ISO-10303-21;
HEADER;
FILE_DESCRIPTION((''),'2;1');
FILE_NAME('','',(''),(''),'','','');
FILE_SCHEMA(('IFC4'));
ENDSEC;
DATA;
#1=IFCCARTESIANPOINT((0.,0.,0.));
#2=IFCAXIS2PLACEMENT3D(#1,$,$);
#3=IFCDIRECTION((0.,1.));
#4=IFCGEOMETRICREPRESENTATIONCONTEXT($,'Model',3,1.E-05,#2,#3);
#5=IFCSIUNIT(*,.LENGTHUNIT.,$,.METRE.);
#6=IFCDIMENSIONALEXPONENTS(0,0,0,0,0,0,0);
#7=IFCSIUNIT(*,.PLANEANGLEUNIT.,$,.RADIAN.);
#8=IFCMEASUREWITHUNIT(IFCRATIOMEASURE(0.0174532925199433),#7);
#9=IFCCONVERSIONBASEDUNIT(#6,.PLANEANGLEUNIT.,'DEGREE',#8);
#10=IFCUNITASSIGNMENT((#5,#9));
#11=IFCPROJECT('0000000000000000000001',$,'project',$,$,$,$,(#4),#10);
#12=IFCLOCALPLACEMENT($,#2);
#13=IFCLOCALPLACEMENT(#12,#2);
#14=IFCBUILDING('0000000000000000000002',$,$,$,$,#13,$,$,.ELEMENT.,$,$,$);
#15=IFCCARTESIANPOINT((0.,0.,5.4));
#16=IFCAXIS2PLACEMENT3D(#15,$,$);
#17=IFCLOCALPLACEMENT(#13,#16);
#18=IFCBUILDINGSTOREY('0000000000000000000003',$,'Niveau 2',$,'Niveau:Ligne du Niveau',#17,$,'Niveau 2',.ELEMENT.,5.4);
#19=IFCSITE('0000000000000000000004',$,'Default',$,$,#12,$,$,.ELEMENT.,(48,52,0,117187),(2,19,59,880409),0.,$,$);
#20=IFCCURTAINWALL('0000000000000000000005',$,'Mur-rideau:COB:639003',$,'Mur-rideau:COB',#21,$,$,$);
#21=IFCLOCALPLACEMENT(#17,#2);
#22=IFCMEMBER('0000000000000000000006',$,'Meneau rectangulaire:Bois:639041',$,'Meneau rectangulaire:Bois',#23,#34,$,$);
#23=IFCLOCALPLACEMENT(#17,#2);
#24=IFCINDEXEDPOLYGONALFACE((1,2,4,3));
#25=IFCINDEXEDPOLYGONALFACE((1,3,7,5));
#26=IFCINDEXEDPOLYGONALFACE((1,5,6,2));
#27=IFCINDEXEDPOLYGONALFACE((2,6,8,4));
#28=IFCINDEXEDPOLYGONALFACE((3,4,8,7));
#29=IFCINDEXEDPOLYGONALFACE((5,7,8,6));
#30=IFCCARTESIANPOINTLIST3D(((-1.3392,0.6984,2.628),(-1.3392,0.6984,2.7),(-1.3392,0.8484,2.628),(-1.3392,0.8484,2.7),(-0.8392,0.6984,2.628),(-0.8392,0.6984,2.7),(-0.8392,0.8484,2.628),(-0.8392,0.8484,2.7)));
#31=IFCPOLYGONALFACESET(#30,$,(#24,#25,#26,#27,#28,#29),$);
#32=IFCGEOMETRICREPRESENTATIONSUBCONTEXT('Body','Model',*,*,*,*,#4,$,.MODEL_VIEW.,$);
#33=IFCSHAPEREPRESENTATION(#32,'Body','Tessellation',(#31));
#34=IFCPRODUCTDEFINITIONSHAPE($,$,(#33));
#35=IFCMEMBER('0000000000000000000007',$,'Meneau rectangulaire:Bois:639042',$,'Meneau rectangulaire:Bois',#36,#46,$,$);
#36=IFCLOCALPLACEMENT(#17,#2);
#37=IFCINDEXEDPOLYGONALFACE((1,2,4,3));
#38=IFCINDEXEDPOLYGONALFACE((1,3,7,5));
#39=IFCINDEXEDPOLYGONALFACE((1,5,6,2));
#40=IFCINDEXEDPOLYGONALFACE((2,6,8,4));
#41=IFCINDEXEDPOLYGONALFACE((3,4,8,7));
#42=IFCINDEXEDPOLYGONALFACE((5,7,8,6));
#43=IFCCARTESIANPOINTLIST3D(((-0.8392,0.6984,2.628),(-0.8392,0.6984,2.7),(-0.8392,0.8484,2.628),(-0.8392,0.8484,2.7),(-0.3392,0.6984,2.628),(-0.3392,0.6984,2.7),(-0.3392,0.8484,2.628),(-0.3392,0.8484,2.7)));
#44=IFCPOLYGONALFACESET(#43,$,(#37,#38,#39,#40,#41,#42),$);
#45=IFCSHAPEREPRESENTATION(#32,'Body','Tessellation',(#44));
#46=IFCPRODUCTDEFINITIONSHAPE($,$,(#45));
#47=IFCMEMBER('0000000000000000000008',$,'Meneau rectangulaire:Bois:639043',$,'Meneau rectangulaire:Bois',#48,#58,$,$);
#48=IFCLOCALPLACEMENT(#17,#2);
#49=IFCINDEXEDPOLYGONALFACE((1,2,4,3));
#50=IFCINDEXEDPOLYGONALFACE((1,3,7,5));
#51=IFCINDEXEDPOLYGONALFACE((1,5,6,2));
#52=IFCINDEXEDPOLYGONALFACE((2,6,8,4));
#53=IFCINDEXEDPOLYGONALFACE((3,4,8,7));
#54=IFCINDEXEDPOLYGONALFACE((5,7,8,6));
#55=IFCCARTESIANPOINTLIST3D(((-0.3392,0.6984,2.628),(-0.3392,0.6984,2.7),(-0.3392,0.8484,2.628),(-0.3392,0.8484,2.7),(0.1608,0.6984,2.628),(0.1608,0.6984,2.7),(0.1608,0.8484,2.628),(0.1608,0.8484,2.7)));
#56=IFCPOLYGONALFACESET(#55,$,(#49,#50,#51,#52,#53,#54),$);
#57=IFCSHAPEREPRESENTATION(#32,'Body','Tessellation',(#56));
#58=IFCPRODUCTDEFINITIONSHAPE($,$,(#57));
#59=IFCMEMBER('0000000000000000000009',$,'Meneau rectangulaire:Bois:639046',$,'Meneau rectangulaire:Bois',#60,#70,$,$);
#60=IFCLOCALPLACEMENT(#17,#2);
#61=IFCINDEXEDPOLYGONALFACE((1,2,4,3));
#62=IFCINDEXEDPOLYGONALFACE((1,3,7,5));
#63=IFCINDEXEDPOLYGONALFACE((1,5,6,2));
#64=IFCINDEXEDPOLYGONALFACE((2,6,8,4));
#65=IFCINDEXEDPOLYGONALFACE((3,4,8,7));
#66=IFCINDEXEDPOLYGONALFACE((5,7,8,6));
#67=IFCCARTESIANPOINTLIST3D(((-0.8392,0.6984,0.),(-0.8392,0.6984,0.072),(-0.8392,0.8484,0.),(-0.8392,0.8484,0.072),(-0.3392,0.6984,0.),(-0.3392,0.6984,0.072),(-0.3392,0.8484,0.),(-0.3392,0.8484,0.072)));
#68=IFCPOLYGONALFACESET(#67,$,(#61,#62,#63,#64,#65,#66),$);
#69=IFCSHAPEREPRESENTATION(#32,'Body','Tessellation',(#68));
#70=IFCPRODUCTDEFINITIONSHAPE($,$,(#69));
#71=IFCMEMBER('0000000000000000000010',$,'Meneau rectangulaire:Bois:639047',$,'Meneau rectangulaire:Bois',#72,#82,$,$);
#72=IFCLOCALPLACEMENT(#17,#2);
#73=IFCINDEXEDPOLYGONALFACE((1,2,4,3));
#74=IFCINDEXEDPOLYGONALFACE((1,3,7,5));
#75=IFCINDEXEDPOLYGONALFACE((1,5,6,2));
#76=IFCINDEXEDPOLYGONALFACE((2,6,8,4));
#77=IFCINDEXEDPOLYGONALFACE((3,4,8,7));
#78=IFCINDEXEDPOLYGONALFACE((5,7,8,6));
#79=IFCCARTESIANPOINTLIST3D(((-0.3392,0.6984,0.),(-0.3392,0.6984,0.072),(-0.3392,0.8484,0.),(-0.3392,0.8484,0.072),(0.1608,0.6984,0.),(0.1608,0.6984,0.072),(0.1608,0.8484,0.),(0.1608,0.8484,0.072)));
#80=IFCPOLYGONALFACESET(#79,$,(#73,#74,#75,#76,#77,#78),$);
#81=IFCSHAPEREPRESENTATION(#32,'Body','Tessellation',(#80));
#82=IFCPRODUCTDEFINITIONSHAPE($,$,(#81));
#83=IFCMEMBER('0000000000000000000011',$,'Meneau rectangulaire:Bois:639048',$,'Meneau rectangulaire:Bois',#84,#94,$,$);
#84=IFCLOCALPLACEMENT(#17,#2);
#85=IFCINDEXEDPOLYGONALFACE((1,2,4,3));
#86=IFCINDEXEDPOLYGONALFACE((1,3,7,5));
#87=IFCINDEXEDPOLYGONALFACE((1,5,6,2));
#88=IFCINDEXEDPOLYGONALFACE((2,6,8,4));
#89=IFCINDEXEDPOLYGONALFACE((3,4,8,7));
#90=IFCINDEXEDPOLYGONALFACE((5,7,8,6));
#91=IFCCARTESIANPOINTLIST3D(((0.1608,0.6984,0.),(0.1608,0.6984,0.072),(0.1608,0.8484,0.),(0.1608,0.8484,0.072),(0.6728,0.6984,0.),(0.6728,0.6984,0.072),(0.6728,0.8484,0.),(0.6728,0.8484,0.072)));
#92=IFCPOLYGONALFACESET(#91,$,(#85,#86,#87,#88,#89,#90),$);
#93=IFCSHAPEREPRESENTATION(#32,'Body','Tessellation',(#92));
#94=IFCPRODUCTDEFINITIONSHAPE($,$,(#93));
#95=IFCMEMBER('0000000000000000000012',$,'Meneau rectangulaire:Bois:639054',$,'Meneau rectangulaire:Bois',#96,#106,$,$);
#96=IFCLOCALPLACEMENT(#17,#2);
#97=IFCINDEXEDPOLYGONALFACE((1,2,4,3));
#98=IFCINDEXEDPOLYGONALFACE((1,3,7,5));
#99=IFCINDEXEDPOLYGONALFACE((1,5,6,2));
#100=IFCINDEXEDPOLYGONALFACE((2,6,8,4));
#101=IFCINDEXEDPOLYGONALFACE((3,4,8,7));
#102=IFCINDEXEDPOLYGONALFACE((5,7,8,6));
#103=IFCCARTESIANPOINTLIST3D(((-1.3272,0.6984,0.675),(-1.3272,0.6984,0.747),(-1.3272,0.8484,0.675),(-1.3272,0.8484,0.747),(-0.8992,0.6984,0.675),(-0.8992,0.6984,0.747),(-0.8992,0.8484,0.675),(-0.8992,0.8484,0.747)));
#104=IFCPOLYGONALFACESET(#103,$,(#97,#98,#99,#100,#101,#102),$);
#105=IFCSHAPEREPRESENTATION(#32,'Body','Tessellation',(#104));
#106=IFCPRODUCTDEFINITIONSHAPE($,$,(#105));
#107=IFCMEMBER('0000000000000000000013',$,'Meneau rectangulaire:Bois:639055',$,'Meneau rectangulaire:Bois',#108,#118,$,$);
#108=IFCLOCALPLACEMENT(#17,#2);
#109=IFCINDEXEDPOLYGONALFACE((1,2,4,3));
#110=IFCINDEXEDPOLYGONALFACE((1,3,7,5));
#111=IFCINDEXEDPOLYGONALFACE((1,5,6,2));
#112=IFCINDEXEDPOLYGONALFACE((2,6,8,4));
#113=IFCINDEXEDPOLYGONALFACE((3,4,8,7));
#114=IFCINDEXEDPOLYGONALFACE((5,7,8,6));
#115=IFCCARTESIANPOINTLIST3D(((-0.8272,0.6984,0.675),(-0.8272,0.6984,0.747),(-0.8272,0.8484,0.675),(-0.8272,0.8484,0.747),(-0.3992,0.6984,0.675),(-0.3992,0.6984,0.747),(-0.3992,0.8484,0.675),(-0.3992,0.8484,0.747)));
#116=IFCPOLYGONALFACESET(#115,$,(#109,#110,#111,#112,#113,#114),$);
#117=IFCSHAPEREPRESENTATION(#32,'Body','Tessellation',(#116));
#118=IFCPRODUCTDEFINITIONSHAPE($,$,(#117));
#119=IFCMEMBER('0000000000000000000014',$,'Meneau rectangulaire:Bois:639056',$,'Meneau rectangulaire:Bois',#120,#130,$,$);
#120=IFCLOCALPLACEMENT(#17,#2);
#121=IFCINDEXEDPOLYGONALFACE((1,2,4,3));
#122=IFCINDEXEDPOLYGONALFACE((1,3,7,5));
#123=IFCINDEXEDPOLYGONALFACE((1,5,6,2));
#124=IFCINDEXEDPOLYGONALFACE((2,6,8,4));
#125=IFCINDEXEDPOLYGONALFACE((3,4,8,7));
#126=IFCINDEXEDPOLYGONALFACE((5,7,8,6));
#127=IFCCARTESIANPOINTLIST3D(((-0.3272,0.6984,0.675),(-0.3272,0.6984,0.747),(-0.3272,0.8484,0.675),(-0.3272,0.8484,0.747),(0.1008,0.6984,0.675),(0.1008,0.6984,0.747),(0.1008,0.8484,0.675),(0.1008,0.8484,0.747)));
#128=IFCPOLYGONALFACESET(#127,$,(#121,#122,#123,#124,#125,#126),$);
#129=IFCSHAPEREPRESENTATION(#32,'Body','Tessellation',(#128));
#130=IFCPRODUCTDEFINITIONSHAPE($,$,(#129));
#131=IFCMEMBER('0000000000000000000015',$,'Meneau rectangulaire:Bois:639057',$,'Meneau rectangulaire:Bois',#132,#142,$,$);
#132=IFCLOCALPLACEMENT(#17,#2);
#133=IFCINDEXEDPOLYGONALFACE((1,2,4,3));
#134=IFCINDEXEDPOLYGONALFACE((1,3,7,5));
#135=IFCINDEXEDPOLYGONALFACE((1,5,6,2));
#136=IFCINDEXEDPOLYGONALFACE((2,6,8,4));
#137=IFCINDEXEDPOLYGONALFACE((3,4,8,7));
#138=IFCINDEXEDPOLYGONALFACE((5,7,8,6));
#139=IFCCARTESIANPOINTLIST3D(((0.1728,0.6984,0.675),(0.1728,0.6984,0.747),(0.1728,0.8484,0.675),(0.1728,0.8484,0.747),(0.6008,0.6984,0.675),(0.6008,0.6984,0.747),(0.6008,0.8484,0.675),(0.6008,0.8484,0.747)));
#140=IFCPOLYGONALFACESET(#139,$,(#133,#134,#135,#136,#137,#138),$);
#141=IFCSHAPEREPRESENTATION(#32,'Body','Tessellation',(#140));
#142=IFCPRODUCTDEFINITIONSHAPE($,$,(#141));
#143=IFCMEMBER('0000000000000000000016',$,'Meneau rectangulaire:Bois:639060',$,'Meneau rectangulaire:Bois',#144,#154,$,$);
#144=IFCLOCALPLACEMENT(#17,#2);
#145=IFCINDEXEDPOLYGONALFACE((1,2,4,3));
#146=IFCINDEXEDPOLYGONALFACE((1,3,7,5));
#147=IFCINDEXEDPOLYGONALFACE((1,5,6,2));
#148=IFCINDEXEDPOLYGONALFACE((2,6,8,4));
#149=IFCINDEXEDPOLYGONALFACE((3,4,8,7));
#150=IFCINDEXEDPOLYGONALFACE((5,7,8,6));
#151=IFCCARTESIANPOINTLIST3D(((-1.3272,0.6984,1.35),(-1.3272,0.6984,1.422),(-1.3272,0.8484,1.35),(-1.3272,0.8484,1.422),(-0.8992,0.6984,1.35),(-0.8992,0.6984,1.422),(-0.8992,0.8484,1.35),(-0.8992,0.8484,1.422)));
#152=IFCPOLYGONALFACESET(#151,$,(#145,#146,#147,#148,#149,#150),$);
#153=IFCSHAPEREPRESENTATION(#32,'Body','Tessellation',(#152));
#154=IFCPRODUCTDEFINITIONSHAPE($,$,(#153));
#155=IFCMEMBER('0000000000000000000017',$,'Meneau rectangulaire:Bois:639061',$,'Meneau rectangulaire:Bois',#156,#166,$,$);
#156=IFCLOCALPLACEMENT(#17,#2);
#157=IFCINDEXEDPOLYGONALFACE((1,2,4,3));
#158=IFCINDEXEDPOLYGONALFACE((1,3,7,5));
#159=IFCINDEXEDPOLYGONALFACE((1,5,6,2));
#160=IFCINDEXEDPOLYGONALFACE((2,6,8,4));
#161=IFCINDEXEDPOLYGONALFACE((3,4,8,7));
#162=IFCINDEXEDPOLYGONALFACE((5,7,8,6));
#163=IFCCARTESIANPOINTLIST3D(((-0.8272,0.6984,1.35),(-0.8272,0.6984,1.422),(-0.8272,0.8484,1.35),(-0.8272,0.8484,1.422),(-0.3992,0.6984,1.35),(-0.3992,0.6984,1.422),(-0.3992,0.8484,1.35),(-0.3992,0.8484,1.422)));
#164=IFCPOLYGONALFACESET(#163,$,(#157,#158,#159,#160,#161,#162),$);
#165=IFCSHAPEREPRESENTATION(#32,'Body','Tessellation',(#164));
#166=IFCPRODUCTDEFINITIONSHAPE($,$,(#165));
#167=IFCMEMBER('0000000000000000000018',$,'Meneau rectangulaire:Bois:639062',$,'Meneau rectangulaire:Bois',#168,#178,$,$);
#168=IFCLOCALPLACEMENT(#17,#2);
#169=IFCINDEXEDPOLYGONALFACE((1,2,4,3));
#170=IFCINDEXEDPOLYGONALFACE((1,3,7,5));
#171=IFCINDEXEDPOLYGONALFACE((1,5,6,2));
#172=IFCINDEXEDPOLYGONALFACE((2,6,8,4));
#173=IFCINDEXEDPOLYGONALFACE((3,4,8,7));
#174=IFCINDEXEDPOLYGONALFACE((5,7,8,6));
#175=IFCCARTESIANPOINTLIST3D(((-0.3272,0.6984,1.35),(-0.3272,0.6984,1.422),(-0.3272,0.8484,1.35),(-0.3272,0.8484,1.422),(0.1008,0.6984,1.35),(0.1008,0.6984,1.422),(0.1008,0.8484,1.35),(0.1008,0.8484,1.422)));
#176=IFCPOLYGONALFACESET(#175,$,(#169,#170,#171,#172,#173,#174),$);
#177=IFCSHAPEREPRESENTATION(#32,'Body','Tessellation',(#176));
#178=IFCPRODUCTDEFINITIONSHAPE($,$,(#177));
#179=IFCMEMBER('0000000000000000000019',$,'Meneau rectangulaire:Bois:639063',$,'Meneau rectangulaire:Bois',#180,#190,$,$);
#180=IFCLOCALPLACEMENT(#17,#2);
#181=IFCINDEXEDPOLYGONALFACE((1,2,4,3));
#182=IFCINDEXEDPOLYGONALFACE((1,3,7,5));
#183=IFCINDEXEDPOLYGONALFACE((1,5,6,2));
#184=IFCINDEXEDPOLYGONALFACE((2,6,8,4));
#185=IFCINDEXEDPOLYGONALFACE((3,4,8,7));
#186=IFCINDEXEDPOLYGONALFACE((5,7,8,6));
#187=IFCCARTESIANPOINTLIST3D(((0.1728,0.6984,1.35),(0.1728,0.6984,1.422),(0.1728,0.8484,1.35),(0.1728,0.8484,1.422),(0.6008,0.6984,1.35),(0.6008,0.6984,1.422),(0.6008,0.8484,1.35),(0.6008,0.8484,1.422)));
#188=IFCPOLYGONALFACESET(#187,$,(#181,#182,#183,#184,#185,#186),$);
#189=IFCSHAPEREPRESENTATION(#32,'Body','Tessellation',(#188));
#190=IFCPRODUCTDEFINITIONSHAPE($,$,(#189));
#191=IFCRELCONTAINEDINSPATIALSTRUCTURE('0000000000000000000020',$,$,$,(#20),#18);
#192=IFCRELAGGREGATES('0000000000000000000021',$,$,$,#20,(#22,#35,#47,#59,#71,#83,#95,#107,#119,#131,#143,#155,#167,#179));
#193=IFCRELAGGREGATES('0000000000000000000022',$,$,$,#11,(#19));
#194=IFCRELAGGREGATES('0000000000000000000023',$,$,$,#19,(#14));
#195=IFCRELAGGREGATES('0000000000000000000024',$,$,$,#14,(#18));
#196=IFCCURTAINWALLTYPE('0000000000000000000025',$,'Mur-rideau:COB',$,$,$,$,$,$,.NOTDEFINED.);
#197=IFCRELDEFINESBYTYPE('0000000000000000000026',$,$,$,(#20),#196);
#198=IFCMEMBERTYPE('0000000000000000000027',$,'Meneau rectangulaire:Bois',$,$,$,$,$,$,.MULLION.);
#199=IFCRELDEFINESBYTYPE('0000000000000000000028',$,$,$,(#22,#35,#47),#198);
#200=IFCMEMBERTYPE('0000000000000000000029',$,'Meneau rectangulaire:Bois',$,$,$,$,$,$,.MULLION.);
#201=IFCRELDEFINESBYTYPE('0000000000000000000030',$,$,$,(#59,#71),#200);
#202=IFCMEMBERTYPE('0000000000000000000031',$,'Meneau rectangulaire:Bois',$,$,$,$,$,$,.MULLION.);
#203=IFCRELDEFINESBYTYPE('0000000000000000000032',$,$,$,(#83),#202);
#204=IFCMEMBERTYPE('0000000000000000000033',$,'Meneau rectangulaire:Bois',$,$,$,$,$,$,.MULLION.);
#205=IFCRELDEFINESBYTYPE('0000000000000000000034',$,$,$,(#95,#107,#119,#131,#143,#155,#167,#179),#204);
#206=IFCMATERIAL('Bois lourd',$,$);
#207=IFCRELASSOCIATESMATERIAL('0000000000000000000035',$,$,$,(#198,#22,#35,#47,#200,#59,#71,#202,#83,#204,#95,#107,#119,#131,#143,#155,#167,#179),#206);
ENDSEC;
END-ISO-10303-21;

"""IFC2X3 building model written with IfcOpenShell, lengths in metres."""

from ifc_helpers import new_model, entity, si_unit, converted_unit, direction, frame, origin, origin_2d_with_axis, place, context, subcontext, project, spatial, rectangle, extrude, source, transform, mapped, material, type_object, type_shapes, element, aggregate, save


model = new_model("IFC2X3")

# Units and contexts
model_context = context("Model", 3, precision=1e-05, world=origin(), true_north=direction((0.0, 1.0)))
body_context = subcontext(model_context, "Body", "Model", "MODEL_VIEW")
ifc_project = project(units=[si_unit("LENGTHUNIT", "METRE"), converted_unit("PLANEANGLEUNIT", "DEGREE", entity("IfcRatioMeasure", 0.0174532925199433), si_unit("PLANEANGLEUNIT", "RADIAN"), dimensions=[0, 0, 0, 0, 0, 0, 0])], contexts=[model_context])

# Site, building, storey
site_placement = place(None, origin())
site = spatial("IfcSite", under=ifc_project, at=site_placement, Name="Default", CompositionType="ELEMENT", RefLatitude=(48, 52, 0, 117187), RefLongitude=(2, 19, 59, 880409), RefElevation=0.0)
building_placement = place(site_placement, origin())
building = spatial("IfcBuilding", under=site, at=building_placement, CompositionType="ELEMENT")
storey_placement = place(building_placement, frame((0.0, 0.0, 5.4)))
storey = spatial("IfcBuildingStorey", under=building, at=storey_placement, Name="Niveau 2", ObjectType="Niveau:Ligne du Niveau", LongName="Niveau 2", CompositionType="ELEMENT", Elevation=5.4)

# Curtain wall, members
curtain_wall_type_1 = type_object("IfcCurtainWallType", Name="Mur-rideau:COB", PredefinedType="NOTDEFINED")
curtain_wall_1_placement = place(storey_placement, frame((0.0, 0.0, -5.4)))
curtain_wall_1 = element("IfcCurtainWall", 1, at=curtain_wall_1_placement, inside=storey, type_object=curtain_wall_type_1, Name="Mur-rideau:COB:639003", ObjectType="Mur-rideau:COB")
ifc_material_1 = material(Name="Bois lourd")
member_type_1 = type_object("IfcMemberType", Name="Meneau rectangulaire:Bois", PredefinedType="MULLION", material=ifc_material_1)
shared_shape_1 = source(origin(), body_context, "Body", "SweptSolid", [
    extrude(rectangle(XDim=0.15, YDim=0.072, at=origin_2d_with_axis()), frame((-0.036, 0.0, -0.5), z_axis=(0.0, 0.0, 1.0), x_axis=(0.0, -1.0, 0.0)), (0.0, 0.0, 1.0), 0.5),
])
type_shapes(member_type_1, [shared_shape_1])
member_1_placement = place(storey_placement, frame((-0.8392, 0.7734, 2.7), z_axis=(1.0, 0.0, 0.0), x_axis=(0.0, 0.0, 1.0)))
member_1 = element("IfcMember", 2, at=member_1_placement, type_object=member_type_1, material=ifc_material_1, Name="Meneau rectangulaire:Bois:639041", ObjectType="Meneau rectangulaire:Bois", context=body_context, shape_type="MappedRepresentation", body=[
    mapped(shared_shape_1, transform((0.0, 0.0, 0.0), scale=1.0)),
])
member_2_placement = place(storey_placement, frame((-0.3392, 0.7734, 2.7), z_axis=(1.0, 0.0, 0.0), x_axis=(0.0, 0.0, 1.0)))
member_2 = element("IfcMember", 3, at=member_2_placement, type_object=member_type_1, material=ifc_material_1, Name="Meneau rectangulaire:Bois:639042", ObjectType="Meneau rectangulaire:Bois", context=body_context, shape_type="MappedRepresentation", body=[
    mapped(shared_shape_1, transform((0.0, 0.0, 0.0), scale=1.0)),
])
member_3_placement = place(storey_placement, frame((0.1608, 0.7734, 2.7), z_axis=(1.0, 0.0, 0.0), x_axis=(0.0, 0.0, 1.0)))
member_3 = element("IfcMember", 4, at=member_3_placement, type_object=member_type_1, material=ifc_material_1, Name="Meneau rectangulaire:Bois:639043", ObjectType="Meneau rectangulaire:Bois", context=body_context, shape_type="MappedRepresentation", body=[
    mapped(shared_shape_1, transform((0.0, 0.0, 0.0), scale=1.0)),
])
member_type_2 = type_object("IfcMemberType", Name="Meneau rectangulaire:Bois", PredefinedType="MULLION", material=ifc_material_1)
shared_shape_2 = source(origin(), body_context, "Body", "SweptSolid", [
    extrude(rectangle(XDim=0.15, YDim=0.072, at=origin_2d_with_axis()), frame((-0.036, 0.0, -0.5), z_axis=(0.0, 0.0, 1.0), x_axis=(0.0, -1.0, 0.0)), (0.0, 0.0, 1.0), 0.5),
])
type_shapes(member_type_2, [shared_shape_2])
member_4_placement = place(storey_placement, frame((-0.8392, 0.7734, 0.0), z_axis=(-1.0, 0.0, 0.0), x_axis=(0.0, 0.0, -1.0)))
member_4 = element("IfcMember", 5, at=member_4_placement, type_object=member_type_2, material=ifc_material_1, Name="Meneau rectangulaire:Bois:639046", ObjectType="Meneau rectangulaire:Bois", context=body_context, shape_type="MappedRepresentation", body=[
    mapped(shared_shape_2, transform((0.0, 0.0, 0.0), scale=1.0)),
])
member_5_placement = place(storey_placement, frame((-0.3392, 0.7734, 0.0), z_axis=(-1.0, 0.0, 0.0), x_axis=(0.0, 0.0, -1.0)))
member_5 = element("IfcMember", 6, at=member_5_placement, type_object=member_type_2, material=ifc_material_1, Name="Meneau rectangulaire:Bois:639047", ObjectType="Meneau rectangulaire:Bois", context=body_context, shape_type="MappedRepresentation", body=[
    mapped(shared_shape_2, transform((0.0, 0.0, 0.0), scale=1.0)),
])
member_type_3 = type_object("IfcMemberType", Name="Meneau rectangulaire:Bois", PredefinedType="MULLION", material=ifc_material_1)
shared_shape_3 = source(origin(), body_context, "Body", "SweptSolid", [
    extrude(rectangle(XDim=0.15, YDim=0.072, at=origin_2d_with_axis()), frame((-0.036, 0.0, -0.512), z_axis=(0.0, 0.0, 1.0), x_axis=(0.0, -1.0, 0.0)), (0.0, 0.0, 1.0), 0.512),
])
type_shapes(member_type_3, [shared_shape_3])
member_6_placement = place(storey_placement, frame((0.1608, 0.7734, 0.0), z_axis=(-1.0, 0.0, 0.0), x_axis=(0.0, 0.0, -1.0)))
member_6 = element("IfcMember", 7, at=member_6_placement, type_object=member_type_3, material=ifc_material_1, Name="Meneau rectangulaire:Bois:639048", ObjectType="Meneau rectangulaire:Bois", context=body_context, shape_type="MappedRepresentation", body=[
    mapped(shared_shape_3, transform((0.0, 0.0, 0.0), scale=1.0)),
])
member_type_4 = type_object("IfcMemberType", Name="Meneau rectangulaire:Bois", PredefinedType="MULLION", material=ifc_material_1)
shared_shape_4 = source(origin(), body_context, "Body", "SweptSolid", [
    extrude(rectangle(XDim=0.15, YDim=0.072, at=origin_2d_with_axis()), frame((-0.024, 0.0, -0.428), z_axis=(0.0, 0.0, 1.0), x_axis=(0.0, -1.0, 0.0)), (0.0, 0.0, 1.0), 0.428),
])
type_shapes(member_type_4, [shared_shape_4])
member_7_placement = place(storey_placement, frame((-0.8992, 0.7734, 0.735), z_axis=(1.0, 0.0, 0.0), x_axis=(0.0, 0.0, 1.0)))
member_7 = element("IfcMember", 8, at=member_7_placement, type_object=member_type_4, material=ifc_material_1, Name="Meneau rectangulaire:Bois:639054", ObjectType="Meneau rectangulaire:Bois", context=body_context, shape_type="MappedRepresentation", body=[
    mapped(shared_shape_4, transform((0.0, 0.0, 0.0), scale=1.0)),
])
member_8_placement = place(storey_placement, frame((-0.3992, 0.7734, 0.735), z_axis=(1.0, 0.0, 0.0), x_axis=(0.0, 0.0, 1.0)))
member_8 = element("IfcMember", 9, at=member_8_placement, type_object=member_type_4, material=ifc_material_1, Name="Meneau rectangulaire:Bois:639055", ObjectType="Meneau rectangulaire:Bois", context=body_context, shape_type="MappedRepresentation", body=[
    mapped(shared_shape_4, transform((0.0, 0.0, 0.0), scale=1.0)),
])
member_9_placement = place(storey_placement, frame((0.1008, 0.7734, 0.735), z_axis=(1.0, 0.0, 0.0), x_axis=(0.0, 0.0, 1.0)))
member_9 = element("IfcMember", 10, at=member_9_placement, type_object=member_type_4, material=ifc_material_1, Name="Meneau rectangulaire:Bois:639056", ObjectType="Meneau rectangulaire:Bois", context=body_context, shape_type="MappedRepresentation", body=[
    mapped(shared_shape_4, transform((0.0, 0.0, 0.0), scale=1.0)),
])
member_10_placement = place(storey_placement, frame((0.6008, 0.7734, 0.735), z_axis=(1.0, 0.0, 0.0), x_axis=(0.0, 0.0, 1.0)))
member_10 = element("IfcMember", 11, at=member_10_placement, type_object=member_type_4, material=ifc_material_1, Name="Meneau rectangulaire:Bois:639057", ObjectType="Meneau rectangulaire:Bois", context=body_context, shape_type="MappedRepresentation", body=[
    mapped(shared_shape_4, transform((0.0, 0.0, 0.0), scale=1.0)),
])
member_11_placement = place(storey_placement, frame((-0.8992, 0.7734, 1.41), z_axis=(1.0, 0.0, 0.0), x_axis=(0.0, 0.0, 1.0)))
member_11 = element("IfcMember", 12, at=member_11_placement, type_object=member_type_4, material=ifc_material_1, Name="Meneau rectangulaire:Bois:639060", ObjectType="Meneau rectangulaire:Bois", context=body_context, shape_type="MappedRepresentation", body=[
    mapped(shared_shape_4, transform((0.0, 0.0, 0.0), scale=1.0)),
])
member_12_placement = place(storey_placement, frame((-0.3992, 0.7734, 1.41), z_axis=(1.0, 0.0, 0.0), x_axis=(0.0, 0.0, 1.0)))
member_12 = element("IfcMember", 13, at=member_12_placement, type_object=member_type_4, material=ifc_material_1, Name="Meneau rectangulaire:Bois:639061", ObjectType="Meneau rectangulaire:Bois", context=body_context, shape_type="MappedRepresentation", body=[
    mapped(shared_shape_4, transform((0.0, 0.0, 0.0), scale=1.0)),
])
member_13_placement = place(storey_placement, frame((0.1008, 0.7734, 1.41), z_axis=(1.0, 0.0, 0.0), x_axis=(0.0, 0.0, 1.0)))
member_13 = element("IfcMember", 14, at=member_13_placement, type_object=member_type_4, material=ifc_material_1, Name="Meneau rectangulaire:Bois:639062", ObjectType="Meneau rectangulaire:Bois", context=body_context, shape_type="MappedRepresentation", body=[
    mapped(shared_shape_4, transform((0.0, 0.0, 0.0), scale=1.0)),
])
member_14_placement = place(storey_placement, frame((0.6008, 0.7734, 1.41), z_axis=(1.0, 0.0, 0.0), x_axis=(0.0, 0.0, 1.0)))
member_14 = element("IfcMember", 15, at=member_14_placement, type_object=member_type_4, material=ifc_material_1, Name="Meneau rectangulaire:Bois:639063", ObjectType="Meneau rectangulaire:Bois", context=body_context, shape_type="MappedRepresentation", body=[
    mapped(shared_shape_4, transform((0.0, 0.0, 0.0), scale=1.0)),
])
aggregate(curtain_wall_1, [member_1, member_2, member_3, member_4, member_5, member_6, member_7, member_8, member_9, member_10, member_11, member_12, member_13, member_14])

save(model, "model.ifc")
